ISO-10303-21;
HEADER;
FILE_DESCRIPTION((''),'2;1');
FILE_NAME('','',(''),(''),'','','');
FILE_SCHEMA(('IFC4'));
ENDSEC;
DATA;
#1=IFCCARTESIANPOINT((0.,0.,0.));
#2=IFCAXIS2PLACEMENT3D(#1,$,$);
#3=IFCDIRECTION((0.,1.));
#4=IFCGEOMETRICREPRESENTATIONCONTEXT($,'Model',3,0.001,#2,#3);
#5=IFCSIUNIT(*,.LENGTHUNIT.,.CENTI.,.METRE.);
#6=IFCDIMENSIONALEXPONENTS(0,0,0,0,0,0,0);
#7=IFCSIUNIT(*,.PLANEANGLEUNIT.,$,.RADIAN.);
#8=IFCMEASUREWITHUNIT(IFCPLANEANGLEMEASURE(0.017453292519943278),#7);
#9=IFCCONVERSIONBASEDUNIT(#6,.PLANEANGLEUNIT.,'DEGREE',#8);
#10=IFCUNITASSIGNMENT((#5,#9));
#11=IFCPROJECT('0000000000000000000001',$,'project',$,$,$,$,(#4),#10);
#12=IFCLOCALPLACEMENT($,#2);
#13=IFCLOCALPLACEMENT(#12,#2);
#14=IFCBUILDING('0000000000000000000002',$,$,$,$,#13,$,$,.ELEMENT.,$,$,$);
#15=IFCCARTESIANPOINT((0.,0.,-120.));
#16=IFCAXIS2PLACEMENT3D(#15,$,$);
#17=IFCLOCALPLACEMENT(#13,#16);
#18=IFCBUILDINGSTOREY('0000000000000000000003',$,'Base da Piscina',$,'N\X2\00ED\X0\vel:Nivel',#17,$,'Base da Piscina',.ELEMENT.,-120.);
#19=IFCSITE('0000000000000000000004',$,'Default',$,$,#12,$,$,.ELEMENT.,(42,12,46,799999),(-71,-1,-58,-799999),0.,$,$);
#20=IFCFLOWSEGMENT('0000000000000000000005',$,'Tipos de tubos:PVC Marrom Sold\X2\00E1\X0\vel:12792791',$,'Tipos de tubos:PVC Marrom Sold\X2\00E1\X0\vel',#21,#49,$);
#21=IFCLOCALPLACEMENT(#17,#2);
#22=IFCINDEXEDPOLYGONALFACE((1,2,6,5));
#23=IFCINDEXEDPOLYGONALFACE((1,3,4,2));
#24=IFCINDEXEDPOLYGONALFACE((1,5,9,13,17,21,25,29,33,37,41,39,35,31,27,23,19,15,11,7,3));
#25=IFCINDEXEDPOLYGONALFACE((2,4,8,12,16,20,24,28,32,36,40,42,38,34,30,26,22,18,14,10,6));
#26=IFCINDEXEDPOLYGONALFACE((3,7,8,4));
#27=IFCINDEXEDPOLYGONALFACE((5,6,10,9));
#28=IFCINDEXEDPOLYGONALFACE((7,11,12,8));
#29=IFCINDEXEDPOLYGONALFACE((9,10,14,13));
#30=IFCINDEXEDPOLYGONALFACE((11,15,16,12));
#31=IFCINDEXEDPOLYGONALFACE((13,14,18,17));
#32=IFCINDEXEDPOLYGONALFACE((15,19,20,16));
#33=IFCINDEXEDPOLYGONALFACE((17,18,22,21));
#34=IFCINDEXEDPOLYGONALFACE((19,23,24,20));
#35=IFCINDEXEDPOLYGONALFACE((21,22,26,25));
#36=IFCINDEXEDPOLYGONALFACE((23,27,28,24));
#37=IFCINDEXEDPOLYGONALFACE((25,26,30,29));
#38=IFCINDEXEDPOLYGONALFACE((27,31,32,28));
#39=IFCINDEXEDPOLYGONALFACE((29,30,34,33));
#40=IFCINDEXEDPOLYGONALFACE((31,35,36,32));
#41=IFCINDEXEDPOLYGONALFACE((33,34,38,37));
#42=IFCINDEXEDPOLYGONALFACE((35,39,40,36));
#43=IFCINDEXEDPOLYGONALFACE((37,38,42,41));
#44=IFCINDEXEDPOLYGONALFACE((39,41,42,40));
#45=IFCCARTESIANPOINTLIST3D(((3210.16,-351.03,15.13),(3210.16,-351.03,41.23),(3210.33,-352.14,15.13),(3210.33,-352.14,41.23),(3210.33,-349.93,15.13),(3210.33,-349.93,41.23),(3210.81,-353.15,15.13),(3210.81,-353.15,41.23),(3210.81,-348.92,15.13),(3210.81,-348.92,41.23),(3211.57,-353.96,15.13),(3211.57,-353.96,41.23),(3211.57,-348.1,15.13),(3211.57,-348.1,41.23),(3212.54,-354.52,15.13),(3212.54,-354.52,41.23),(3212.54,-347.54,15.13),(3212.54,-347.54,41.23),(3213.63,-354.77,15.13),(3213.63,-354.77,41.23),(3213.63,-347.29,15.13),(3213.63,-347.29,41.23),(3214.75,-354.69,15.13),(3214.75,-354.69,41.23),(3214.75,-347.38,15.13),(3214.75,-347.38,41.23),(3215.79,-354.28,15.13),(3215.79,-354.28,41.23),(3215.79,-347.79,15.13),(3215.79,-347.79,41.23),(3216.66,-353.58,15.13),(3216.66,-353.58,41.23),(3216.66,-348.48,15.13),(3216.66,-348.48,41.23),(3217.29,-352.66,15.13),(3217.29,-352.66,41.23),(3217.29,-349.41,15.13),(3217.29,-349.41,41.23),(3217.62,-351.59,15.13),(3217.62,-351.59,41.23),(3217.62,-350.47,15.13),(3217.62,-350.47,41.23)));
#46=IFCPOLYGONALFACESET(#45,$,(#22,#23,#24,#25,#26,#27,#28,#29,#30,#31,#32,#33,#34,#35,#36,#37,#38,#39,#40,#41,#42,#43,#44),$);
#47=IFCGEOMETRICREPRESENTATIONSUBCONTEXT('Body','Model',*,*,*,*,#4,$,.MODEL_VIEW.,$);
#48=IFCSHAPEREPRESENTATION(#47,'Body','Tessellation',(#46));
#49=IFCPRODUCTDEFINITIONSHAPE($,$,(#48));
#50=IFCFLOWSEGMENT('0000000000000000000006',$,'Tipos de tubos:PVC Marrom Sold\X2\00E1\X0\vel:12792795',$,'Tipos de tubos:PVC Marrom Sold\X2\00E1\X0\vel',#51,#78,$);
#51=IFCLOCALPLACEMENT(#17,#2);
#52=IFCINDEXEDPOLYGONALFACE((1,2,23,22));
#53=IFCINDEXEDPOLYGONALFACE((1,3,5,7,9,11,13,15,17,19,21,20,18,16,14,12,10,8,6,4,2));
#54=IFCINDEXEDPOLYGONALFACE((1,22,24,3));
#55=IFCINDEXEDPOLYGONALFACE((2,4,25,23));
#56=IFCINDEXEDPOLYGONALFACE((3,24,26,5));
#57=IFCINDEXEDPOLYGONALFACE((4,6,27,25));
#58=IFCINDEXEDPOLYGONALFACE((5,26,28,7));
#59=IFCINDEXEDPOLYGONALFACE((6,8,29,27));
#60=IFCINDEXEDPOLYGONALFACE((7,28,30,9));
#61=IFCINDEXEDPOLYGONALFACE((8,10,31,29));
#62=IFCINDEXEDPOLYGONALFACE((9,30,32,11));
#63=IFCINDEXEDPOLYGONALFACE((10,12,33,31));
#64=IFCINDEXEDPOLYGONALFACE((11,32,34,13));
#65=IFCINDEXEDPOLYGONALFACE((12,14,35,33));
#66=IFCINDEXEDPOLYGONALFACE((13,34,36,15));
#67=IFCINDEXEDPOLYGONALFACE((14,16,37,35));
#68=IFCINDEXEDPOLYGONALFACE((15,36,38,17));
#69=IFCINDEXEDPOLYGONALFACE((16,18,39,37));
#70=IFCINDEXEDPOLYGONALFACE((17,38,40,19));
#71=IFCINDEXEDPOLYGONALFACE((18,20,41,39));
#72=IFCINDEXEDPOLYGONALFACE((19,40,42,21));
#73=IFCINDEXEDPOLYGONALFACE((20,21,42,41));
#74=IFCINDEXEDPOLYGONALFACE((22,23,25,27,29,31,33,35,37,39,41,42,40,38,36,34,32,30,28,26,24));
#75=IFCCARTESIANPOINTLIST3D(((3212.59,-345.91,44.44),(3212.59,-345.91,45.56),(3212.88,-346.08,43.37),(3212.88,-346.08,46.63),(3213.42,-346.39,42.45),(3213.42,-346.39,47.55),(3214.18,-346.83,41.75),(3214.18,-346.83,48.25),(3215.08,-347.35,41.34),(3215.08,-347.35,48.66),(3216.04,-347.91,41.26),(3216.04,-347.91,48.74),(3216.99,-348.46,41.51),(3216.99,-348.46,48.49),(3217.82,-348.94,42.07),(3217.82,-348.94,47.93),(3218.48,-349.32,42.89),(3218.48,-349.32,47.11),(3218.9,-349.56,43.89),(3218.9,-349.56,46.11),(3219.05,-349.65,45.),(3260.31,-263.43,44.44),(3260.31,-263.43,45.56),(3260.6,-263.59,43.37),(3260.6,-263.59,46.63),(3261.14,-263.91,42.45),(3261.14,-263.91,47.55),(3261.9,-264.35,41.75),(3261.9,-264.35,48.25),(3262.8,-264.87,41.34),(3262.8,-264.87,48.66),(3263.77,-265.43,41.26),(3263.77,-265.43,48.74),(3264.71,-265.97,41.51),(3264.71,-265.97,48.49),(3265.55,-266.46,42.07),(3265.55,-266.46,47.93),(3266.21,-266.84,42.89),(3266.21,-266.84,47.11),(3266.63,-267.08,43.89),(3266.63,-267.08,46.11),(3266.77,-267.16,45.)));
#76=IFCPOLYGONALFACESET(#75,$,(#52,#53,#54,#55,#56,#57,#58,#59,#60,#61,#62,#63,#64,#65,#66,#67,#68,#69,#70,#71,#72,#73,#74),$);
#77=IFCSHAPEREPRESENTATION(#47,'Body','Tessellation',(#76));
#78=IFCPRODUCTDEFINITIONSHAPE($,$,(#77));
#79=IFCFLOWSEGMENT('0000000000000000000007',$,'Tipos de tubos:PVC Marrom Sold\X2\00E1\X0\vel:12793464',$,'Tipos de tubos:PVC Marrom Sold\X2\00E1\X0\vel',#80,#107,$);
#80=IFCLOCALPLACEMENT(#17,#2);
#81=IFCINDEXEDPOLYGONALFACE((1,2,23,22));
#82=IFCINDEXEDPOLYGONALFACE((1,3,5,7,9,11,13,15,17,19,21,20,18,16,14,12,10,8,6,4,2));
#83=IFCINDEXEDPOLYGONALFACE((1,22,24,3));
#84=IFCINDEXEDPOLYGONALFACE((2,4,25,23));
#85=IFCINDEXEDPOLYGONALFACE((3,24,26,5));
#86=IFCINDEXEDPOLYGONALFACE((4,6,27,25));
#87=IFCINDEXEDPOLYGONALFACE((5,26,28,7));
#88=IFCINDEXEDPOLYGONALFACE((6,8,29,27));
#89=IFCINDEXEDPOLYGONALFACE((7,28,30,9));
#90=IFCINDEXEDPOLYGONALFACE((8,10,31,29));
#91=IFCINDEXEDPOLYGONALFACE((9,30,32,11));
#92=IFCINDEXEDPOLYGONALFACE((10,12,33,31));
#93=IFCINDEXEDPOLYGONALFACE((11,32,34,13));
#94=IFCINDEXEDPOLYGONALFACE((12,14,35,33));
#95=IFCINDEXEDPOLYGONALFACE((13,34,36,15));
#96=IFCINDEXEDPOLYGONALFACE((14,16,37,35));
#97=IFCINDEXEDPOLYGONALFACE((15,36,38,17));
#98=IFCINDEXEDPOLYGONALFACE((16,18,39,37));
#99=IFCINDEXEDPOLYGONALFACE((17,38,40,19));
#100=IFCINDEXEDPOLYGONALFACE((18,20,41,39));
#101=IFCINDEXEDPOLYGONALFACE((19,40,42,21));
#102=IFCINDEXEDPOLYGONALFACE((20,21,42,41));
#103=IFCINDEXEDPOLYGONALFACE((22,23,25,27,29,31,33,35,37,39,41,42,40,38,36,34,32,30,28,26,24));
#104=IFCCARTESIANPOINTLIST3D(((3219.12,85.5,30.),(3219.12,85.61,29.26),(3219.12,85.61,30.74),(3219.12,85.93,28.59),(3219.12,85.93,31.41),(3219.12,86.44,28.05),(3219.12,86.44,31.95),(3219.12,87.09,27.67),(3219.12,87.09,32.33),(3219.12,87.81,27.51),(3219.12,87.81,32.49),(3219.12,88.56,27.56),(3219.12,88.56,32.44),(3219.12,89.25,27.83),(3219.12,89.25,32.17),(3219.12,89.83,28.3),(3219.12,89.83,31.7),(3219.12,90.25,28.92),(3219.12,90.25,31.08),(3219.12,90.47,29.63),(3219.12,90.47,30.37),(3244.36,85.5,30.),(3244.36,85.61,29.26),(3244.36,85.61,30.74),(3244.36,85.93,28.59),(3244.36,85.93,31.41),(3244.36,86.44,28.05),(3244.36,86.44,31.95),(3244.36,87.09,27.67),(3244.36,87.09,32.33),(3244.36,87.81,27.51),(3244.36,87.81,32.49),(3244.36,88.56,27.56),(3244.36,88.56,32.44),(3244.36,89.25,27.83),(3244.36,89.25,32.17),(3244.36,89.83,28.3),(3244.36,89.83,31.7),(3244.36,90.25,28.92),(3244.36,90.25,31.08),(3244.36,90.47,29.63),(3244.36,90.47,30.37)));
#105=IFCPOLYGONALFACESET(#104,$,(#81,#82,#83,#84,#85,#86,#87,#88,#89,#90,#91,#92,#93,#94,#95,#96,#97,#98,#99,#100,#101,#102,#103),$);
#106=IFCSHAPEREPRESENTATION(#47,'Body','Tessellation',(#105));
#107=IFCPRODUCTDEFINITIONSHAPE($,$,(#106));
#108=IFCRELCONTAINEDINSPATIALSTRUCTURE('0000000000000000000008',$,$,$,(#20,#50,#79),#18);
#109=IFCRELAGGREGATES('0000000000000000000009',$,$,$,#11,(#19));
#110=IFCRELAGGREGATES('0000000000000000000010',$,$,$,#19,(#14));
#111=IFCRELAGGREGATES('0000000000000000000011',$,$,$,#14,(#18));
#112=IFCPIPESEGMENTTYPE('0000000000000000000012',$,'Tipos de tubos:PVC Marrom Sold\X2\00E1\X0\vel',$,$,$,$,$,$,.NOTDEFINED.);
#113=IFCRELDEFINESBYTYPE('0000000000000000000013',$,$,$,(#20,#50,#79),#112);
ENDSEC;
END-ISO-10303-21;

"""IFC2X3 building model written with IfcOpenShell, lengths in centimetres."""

from ifc_helpers import new_model, entity, si_unit, converted_unit, direction, frame, frame_2d, origin, origin_2d_with_axis, place, context, subcontext, project, spatial, circle, extrude, type_object, element, save


model = new_model("IFC2X3")

# Units and contexts
model_context = context("Model", 3, precision=0.001, world=origin(), true_north=direction((0.0, 1.0)))
body_context = subcontext(model_context, "Body", "Model", "MODEL_VIEW")
ifc_project = project(units=[si_unit("LENGTHUNIT", "METRE", prefix="CENTI"), converted_unit("PLANEANGLEUNIT", "DEGREE", entity("IfcPlaneAngleMeasure", 0.017453292519943278), si_unit("PLANEANGLEUNIT", "RADIAN"), dimensions=[0, 0, 0, 0, 0, 0, 0])], contexts=[model_context])

# Site, building, storey
site_placement = place(None, origin())
site = spatial("IfcSite", under=ifc_project, at=site_placement, Name="Default", CompositionType="ELEMENT", RefLatitude=(42, 12, 46, 799999), RefLongitude=(-71, -1, -58, -799999), RefElevation=0.0)
building_placement = place(site_placement, origin())
building = spatial("IfcBuilding", under=site, at=building_placement, CompositionType="ELEMENT")
storey_placement = place(building_placement, frame((0.0, 0.0, -120.0)))
storey = spatial("IfcBuildingStorey", under=building, at=storey_placement, Name="Base da Piscina", ObjectType="Nível:Nivel", LongName="Base da Piscina", CompositionType="ELEMENT", Elevation=-120.0)

# Flow segments
pipe_segment_type = type_object("IfcPipeSegmentType", Name="Tipos de tubos:PVC Marrom Soldável", PredefinedType="NOTDEFINED")
flow_segment_1_placement = place(storey_placement, origin())
element("IfcFlowSegment", 1, at=flow_segment_1_placement, inside=storey, type_object=pipe_segment_type, Name="Tipos de tubos:PVC Marrom Soldável:12792791", ObjectType="Tipos de tubos:PVC Marrom Soldável", context=body_context, shape_type="SweptSolid", body=[
    extrude(circle(Radius=3.75, at=origin_2d_with_axis()), frame((3213.91, -351.03, 15.13), z_axis=(0.0, 0.0, 1.0), x_axis=(-1.0, 0.0, 0.0)), (0.0, 0.0, 1.0), 26.1),
])
flow_segment_2_placement = place(storey_placement, origin())
element("IfcFlowSegment", 2, at=flow_segment_2_placement, inside=storey, type_object=pipe_segment_type, Name="Tipos de tubos:PVC Marrom Soldável:12792795", ObjectType="Tipos de tubos:PVC Marrom Soldável", context=body_context, shape_type="SweptSolid", body=[
    extrude(circle(Radius=3.75, at=frame_2d((0.0, 0.0), x_axis=(1.0, 0.0))), frame((3215.8, -347.77, 45.0), z_axis=(0.50079, 0.865569, 0.0), x_axis=(0.865569, -0.50079, 0.0)), (0.0, 0.0, 1.0), 95.3),
])
flow_segment_3_placement = place(storey_placement, origin())
element("IfcFlowSegment", 3, at=flow_segment_3_placement, inside=storey, type_object=pipe_segment_type, Name="Tipos de tubos:PVC Marrom Soldável:12793464", ObjectType="Tipos de tubos:PVC Marrom Soldável", context=body_context, shape_type="SweptSolid", body=[
    extrude(circle(Radius=2.5, at=origin_2d_with_axis()), frame((3219.12, 88.0, 30.0), z_axis=(1.0, 0.0, 0.0), x_axis=(0.0, -1.0, 0.0)), (0.0, 0.0, 1.0), 25.24),
])

save(model, "model.ifc")
